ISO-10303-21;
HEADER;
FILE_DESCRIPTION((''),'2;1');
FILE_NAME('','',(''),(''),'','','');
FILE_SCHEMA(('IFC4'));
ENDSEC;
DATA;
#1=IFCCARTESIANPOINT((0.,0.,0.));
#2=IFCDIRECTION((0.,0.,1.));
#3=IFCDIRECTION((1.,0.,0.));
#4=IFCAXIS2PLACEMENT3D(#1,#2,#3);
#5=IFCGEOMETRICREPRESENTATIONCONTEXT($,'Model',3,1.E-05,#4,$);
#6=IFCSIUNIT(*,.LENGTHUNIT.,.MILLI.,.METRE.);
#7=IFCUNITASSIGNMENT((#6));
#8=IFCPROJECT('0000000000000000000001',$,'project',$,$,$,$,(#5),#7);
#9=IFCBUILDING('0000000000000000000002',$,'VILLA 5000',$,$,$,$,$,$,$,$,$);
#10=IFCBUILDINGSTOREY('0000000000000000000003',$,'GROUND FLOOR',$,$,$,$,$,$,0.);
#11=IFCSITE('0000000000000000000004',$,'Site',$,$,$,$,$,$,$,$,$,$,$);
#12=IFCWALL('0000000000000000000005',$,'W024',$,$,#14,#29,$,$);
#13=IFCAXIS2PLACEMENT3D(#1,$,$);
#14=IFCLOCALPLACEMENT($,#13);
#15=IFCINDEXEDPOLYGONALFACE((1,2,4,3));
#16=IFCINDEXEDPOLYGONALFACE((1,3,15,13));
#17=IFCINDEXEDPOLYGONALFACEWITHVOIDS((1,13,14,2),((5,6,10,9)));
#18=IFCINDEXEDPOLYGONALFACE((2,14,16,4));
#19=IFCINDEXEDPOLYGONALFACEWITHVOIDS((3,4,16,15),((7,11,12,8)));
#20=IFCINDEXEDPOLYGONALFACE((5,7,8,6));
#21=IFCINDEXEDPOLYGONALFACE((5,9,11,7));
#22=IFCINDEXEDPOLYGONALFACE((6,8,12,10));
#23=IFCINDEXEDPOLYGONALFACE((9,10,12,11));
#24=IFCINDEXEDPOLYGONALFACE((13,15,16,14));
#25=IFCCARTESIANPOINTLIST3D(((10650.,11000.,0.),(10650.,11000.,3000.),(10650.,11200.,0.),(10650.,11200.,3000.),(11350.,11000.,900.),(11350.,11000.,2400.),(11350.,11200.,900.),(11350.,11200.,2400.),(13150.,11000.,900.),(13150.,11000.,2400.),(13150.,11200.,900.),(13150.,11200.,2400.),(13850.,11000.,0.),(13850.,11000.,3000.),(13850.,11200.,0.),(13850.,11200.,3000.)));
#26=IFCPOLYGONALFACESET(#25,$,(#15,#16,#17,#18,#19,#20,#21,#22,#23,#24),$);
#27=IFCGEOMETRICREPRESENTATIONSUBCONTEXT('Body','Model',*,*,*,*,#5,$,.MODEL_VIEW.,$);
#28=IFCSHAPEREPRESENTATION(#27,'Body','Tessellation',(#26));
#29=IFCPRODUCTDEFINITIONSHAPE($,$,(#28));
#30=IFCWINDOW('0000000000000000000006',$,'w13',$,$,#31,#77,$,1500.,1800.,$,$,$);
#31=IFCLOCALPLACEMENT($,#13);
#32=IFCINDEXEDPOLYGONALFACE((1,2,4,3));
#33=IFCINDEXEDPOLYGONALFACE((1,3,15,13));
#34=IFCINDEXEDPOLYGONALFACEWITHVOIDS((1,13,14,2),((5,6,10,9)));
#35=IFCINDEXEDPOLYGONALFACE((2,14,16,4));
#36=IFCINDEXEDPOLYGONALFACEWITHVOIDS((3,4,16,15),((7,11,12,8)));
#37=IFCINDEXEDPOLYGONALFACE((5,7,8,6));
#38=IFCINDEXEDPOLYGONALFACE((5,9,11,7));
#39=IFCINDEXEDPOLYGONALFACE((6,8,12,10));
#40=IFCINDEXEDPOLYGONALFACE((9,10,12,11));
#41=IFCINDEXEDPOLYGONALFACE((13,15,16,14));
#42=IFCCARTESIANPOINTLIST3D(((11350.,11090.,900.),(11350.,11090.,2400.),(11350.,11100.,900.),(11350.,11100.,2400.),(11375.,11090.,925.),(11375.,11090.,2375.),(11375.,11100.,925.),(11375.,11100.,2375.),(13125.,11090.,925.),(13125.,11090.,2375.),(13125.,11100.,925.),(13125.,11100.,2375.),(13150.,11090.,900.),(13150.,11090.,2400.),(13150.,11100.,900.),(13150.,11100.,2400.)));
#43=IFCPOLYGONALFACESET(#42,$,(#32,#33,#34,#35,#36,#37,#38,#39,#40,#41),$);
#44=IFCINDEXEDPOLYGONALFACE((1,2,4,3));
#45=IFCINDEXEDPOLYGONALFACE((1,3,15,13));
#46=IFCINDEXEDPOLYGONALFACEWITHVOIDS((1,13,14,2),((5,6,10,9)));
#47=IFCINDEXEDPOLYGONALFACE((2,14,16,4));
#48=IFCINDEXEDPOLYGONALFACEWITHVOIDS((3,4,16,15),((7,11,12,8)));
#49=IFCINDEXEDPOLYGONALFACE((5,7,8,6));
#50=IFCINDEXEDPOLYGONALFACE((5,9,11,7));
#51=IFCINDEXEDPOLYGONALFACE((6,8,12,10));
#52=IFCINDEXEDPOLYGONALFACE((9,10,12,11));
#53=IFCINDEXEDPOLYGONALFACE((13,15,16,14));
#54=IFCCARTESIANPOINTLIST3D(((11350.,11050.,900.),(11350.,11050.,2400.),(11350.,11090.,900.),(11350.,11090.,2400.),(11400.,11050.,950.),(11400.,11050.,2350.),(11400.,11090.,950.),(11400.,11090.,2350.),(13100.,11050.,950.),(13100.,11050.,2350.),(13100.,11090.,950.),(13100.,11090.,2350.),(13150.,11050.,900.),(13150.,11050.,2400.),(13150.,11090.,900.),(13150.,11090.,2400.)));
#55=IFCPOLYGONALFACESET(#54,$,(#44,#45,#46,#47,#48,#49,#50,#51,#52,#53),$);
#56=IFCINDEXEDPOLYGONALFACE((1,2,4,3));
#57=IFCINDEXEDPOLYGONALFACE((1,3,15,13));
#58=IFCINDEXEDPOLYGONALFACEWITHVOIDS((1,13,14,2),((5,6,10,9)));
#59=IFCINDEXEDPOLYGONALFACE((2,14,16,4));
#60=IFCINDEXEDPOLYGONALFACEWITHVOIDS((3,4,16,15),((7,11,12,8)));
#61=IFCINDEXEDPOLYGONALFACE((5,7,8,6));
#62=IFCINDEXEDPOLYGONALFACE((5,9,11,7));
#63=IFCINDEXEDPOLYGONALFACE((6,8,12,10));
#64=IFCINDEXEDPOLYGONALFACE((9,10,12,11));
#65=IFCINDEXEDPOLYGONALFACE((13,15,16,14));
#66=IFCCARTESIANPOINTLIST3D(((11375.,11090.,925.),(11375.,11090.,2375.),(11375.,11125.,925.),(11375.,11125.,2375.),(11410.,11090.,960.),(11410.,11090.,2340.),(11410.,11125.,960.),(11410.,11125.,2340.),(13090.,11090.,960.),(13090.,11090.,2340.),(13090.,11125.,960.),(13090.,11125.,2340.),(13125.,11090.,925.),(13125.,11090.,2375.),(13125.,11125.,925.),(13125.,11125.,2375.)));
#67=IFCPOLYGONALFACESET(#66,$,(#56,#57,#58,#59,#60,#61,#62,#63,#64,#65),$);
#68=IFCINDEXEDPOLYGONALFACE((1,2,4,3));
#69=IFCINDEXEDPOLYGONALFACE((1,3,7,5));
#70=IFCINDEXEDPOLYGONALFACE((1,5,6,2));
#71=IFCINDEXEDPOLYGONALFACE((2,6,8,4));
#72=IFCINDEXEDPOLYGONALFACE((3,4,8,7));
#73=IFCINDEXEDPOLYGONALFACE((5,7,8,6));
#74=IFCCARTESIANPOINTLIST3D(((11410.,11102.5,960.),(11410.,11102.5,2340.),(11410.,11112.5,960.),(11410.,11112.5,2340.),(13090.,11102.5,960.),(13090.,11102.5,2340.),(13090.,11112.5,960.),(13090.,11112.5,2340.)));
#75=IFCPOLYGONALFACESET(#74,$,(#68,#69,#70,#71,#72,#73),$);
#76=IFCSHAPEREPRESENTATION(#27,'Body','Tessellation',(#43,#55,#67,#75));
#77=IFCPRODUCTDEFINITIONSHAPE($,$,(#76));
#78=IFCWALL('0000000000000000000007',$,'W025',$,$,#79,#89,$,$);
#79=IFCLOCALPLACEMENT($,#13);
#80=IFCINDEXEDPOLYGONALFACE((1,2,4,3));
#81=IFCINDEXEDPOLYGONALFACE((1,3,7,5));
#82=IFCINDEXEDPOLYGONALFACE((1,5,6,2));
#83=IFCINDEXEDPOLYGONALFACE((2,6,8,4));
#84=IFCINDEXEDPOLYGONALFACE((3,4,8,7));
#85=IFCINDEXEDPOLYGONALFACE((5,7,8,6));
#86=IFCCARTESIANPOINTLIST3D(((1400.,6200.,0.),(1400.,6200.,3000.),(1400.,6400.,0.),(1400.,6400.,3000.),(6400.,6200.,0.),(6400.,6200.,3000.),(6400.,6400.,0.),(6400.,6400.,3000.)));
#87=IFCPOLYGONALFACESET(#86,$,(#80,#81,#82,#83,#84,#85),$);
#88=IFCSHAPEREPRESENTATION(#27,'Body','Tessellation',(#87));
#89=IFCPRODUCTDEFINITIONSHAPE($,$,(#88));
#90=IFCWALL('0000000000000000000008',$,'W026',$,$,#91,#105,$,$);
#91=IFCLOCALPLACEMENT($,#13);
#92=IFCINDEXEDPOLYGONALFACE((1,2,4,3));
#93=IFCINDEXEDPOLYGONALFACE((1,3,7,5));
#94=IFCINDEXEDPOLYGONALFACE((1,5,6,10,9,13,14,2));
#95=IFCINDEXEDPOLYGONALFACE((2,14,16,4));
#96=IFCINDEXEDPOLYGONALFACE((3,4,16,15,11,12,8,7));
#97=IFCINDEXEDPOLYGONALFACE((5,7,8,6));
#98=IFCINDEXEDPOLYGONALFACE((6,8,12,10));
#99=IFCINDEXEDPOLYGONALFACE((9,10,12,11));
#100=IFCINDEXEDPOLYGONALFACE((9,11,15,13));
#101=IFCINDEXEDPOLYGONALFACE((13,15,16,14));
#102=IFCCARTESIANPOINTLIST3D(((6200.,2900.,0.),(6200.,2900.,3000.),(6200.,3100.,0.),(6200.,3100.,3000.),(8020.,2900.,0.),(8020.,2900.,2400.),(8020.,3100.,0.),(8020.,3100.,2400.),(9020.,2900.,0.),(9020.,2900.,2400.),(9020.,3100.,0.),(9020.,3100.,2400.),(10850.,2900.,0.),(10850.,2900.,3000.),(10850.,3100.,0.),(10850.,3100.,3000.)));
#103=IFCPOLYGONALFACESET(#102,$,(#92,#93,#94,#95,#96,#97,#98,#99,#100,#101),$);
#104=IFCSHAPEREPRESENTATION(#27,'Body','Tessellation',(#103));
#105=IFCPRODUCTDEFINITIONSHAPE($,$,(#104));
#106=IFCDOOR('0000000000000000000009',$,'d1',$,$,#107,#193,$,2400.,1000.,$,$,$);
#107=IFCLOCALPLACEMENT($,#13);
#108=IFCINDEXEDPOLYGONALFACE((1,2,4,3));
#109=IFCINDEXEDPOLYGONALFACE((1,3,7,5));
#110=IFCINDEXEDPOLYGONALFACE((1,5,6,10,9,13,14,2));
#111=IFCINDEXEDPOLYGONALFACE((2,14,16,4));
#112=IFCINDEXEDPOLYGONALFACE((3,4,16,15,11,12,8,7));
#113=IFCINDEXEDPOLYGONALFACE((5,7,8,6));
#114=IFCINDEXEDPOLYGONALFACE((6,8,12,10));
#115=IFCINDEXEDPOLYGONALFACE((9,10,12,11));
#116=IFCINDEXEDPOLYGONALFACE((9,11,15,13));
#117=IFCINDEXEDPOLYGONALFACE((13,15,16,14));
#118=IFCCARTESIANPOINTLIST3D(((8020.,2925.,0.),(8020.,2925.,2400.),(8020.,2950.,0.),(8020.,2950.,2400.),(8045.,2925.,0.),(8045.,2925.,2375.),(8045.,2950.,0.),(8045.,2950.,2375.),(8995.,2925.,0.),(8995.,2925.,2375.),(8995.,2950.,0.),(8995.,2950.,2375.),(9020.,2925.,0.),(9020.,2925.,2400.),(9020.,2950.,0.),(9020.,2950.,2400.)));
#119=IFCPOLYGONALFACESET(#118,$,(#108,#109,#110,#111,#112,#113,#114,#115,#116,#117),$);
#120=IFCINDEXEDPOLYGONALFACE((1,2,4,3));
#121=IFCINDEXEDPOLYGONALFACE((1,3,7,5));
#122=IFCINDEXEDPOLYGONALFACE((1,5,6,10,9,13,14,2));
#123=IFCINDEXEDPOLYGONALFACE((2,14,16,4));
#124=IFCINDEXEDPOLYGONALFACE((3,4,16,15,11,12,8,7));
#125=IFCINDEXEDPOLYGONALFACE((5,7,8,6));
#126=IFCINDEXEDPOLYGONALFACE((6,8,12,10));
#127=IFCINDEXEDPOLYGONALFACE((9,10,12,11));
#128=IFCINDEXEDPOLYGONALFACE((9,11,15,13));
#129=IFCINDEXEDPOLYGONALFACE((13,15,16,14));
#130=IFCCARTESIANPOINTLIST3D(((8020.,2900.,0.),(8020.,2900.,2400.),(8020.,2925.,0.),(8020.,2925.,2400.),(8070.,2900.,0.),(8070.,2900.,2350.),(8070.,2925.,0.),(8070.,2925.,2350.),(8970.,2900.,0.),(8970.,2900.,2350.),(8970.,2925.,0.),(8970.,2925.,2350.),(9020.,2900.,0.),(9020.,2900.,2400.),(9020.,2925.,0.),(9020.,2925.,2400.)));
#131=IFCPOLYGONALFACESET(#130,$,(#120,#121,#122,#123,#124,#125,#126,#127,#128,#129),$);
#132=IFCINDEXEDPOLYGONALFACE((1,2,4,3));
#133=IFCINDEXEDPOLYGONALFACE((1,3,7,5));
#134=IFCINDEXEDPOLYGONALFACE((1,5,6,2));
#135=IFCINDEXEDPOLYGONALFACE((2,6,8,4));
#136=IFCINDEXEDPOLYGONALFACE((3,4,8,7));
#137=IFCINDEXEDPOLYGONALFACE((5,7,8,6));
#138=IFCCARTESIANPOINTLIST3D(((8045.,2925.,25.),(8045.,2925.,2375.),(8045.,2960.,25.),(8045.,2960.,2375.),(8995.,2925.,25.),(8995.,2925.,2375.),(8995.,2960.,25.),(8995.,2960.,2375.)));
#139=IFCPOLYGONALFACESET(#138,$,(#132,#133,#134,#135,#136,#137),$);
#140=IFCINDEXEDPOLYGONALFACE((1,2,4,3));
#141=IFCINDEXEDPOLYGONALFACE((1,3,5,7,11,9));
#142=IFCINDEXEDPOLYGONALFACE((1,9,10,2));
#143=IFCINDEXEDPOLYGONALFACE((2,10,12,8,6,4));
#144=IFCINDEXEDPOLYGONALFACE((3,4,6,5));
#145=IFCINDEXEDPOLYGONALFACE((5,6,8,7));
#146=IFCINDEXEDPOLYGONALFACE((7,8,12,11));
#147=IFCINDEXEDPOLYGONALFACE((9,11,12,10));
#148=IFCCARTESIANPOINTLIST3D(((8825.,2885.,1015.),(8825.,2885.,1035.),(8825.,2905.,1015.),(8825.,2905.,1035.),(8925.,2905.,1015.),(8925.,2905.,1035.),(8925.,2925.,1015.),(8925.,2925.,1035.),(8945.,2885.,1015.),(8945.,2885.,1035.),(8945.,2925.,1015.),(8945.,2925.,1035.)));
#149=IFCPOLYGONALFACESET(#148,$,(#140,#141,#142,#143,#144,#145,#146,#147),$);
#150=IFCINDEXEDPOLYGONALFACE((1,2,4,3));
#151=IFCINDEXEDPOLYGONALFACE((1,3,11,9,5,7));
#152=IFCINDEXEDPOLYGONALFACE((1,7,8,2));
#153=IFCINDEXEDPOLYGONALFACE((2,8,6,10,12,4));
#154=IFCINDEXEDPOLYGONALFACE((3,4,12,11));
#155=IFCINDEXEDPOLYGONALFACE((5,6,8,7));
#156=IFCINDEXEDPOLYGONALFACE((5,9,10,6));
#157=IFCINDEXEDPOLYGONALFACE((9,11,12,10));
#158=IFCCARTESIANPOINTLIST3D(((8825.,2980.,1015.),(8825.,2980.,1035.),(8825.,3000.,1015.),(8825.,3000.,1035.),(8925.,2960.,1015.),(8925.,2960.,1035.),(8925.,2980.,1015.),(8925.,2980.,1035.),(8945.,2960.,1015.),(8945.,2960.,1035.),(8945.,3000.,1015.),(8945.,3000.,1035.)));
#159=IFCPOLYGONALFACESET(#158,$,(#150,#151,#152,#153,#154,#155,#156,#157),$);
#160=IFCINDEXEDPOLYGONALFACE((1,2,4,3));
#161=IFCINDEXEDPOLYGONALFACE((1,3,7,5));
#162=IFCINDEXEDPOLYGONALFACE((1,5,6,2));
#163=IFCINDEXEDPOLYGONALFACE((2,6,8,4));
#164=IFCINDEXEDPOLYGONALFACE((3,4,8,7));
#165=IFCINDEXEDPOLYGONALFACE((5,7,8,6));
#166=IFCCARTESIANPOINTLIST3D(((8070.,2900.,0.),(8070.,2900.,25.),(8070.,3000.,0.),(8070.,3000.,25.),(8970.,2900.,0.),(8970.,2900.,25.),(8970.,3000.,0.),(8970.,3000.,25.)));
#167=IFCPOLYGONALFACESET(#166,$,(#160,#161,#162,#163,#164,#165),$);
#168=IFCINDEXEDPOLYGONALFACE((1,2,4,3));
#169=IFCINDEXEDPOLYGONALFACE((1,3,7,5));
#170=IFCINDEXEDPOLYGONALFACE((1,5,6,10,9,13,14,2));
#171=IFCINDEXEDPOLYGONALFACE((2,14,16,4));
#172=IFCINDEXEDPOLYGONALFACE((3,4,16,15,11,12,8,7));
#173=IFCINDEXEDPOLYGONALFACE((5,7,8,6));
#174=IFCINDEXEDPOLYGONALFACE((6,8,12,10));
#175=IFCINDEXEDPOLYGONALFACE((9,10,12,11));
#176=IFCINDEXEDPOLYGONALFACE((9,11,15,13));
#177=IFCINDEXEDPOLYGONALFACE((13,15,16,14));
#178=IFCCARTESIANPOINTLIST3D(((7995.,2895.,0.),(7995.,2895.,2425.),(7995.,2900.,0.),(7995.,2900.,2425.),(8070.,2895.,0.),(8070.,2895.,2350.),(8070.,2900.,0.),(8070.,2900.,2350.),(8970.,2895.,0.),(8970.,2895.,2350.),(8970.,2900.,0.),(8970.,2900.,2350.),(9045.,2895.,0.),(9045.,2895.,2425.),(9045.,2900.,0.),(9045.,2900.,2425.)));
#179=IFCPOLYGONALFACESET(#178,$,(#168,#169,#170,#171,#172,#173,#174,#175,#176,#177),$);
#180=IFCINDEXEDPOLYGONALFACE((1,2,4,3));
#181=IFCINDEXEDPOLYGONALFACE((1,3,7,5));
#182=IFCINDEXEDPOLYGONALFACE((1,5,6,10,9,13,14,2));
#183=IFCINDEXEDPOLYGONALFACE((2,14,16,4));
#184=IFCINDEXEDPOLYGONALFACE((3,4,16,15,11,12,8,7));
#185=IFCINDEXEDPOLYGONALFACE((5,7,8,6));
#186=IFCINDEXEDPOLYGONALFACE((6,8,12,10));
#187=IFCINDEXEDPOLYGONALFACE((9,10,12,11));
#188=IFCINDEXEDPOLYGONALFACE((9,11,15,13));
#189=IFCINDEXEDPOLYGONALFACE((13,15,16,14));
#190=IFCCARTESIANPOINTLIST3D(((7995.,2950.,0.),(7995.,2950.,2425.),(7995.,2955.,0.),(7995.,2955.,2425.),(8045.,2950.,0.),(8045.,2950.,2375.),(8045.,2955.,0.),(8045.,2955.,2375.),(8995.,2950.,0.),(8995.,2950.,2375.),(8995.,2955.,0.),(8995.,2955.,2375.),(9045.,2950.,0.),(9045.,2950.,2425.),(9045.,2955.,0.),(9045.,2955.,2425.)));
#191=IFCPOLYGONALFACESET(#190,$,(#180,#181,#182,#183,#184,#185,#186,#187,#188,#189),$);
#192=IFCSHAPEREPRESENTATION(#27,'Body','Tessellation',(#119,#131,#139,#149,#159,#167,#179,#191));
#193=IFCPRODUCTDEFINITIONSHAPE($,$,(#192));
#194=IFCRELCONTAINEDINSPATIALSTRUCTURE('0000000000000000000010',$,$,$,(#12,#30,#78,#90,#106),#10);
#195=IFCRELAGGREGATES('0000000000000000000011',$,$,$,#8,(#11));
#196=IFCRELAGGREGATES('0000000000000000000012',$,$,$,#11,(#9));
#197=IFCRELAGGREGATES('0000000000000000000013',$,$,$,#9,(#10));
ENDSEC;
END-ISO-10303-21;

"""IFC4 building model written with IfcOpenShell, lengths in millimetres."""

from ifc_helpers import new_model, si_unit, frame, origin_with_axes, place, context, subcontext, project, spatial, line, indexed_curve, outline, extrude, element, fill, save


model = new_model("IFC4")

# Units and contexts
model_context = context("Model", 3, precision=1e-05, world=origin_with_axes())
body_context = subcontext(model_context, "Body", "Model", "MODEL_VIEW")
ifc_project = project(units=[si_unit("LENGTHUNIT", "METRE", prefix="MILLI")], contexts=[model_context])

# Site, building, storey
site = spatial("IfcSite", under=ifc_project, Name="Site")
building = spatial("IfcBuilding", under=site, Name="VILLA 5000")
storey = spatial("IfcBuildingStorey", under=building, Name="GROUND FLOOR", Elevation=0.0)

# Wall, opening, window
wall_1_placement = place(None, frame((10650.0, 11100.0, 0.0), z_axis=(0.0, 0.0, 1.0), x_axis=(1.0, 0.0, 0.0)))
wall_1 = element("IfcWall", 1, at=wall_1_placement, inside=storey, Name="W024", context=body_context, shape_type="SweptSolid", body=[
    extrude(outline(indexed_curve([(0.0, 0.0), (0.0, 200.0), (3200.0, 200.0), (3200.0, 0.0), (0.0, 0.0)], self_intersect=False)), frame((0.0, -100.0, 0.0), z_axis=(0.0, 0.0, 1.0), x_axis=(1.0, 0.0, 0.0)), (0.0, 0.0, 1.0), 3000.0),
])
opening_1_placement = place(wall_1_placement, frame((700.0, 0.0, 900.0), z_axis=(0.0, 0.0, 1.0), x_axis=(1.0, 0.0, 0.0)))
opening_1 = element("IfcOpeningElement", 2, at=opening_1_placement, cuts=wall_1, context=body_context, shape_type="SweptSolid", body=[
    extrude(outline(indexed_curve([(0.0, 0.0), (0.0, 300.0), (1800.0, 300.0), (1800.0, 0.0), (0.0, 0.0)], self_intersect=False)), frame((0.0, -150.0, 0.0), z_axis=(0.0, 0.0, 1.0), x_axis=(1.0, 0.0, 0.0)), (0.0, 0.0, 1.0), 1500.0),
])
window_1_placement = place(None, frame((11350.0, 11000.0, 900.0), z_axis=(0.0, 0.0, 1.0), x_axis=(1.0, 0.0, 0.0)))
window_1 = element("IfcWindow", 3, at=window_1_placement, inside=storey, Name="w13", OverallHeight=1500.0, OverallWidth=1800.0, context=body_context, shape_type="SweptSolid", body=[
    extrude(outline(indexed_curve([(0.0, 0.0), (1800.0, 0.0), (1800.0, 1500.0), (0.0, 1500.0)], segments=[line(1, 2, 3, 4, 1)]), holes=[indexed_curve([(25.0, 25.0), (1775.0, 25.0), (1775.0, 1475.0), (25.0, 1475.0)], segments=[line(1, 2, 3, 4, 1)])]), frame((0.0, 90.0, 0.0), z_axis=(0.0, -1.0, 0.0), x_axis=(1.0, 0.0, 0.0)), (0.0, 0.0, -1.0), 10.0),
    extrude(outline(indexed_curve([(0.0, 0.0), (1800.0, 0.0), (1800.0, 1500.0), (0.0, 1500.0)], segments=[line(1, 2, 3, 4, 1)]), holes=[indexed_curve([(50.0, 50.0), (1750.0, 50.0), (1750.0, 1450.0), (50.0, 1450.0)], segments=[line(1, 2, 3, 4, 1)])]), frame((0.0, 50.0, 0.0), z_axis=(0.0, -1.0, 0.0), x_axis=(1.0, 0.0, 0.0)), (0.0, 0.0, -1.0), 40.0),
    extrude(outline(indexed_curve([(0.0, 0.0), (1750.0, 0.0), (1750.0, 1450.0), (0.0, 1450.0)], segments=[line(1, 2, 3, 4, 1)]), holes=[indexed_curve([(35.0, 35.0), (1715.0, 35.0), (1715.0, 1415.0), (35.0, 1415.0)], segments=[line(1, 2, 3, 4, 1)])]), frame((25.0, 90.0, 25.0), z_axis=(0.0, -1.0, 0.0), x_axis=(1.0, 0.0, 0.0)), (0.0, 0.0, -1.0), 35.0),
    extrude(outline(indexed_curve([(35.0, 35.0), (1715.0, 35.0), (1715.0, 1415.0), (35.0, 1415.0)], segments=[line(1, 2, 3, 4, 1)])), frame((25.0, 102.5, 25.0), z_axis=(0.0, -1.0, 0.0), x_axis=(1.0, 0.0, 0.0)), (0.0, 0.0, -1.0), 10.0),
])
fill(opening_1, window_1)

# Wall
wall_2_placement = place(None, frame((1400.0, 6300.0, 0.0), z_axis=(0.0, 0.0, 1.0), x_axis=(1.0, 0.0, 0.0)))
element("IfcWall", 4, at=wall_2_placement, inside=storey, Name="W025", context=body_context, shape_type="SweptSolid", body=[
    extrude(outline(indexed_curve([(0.0, 0.0), (0.0, 200.0), (5000.0, 200.0), (5000.0, 0.0), (0.0, 0.0)], self_intersect=False)), frame((0.0, -100.0, 0.0), z_axis=(0.0, 0.0, 1.0), x_axis=(1.0, 0.0, 0.0)), (0.0, 0.0, 1.0), 3000.0),
])

# Wall, opening, door
wall_3_placement = place(None, frame((6200.0, 3000.0, 0.0), z_axis=(0.0, 0.0, 1.0), x_axis=(1.0, 0.0, 0.0)))
wall_3 = element("IfcWall", 5, at=wall_3_placement, inside=storey, Name="W026", context=body_context, shape_type="SweptSolid", body=[
    extrude(outline(indexed_curve([(0.0, 0.0), (0.0, 200.0), (4650.0, 200.0), (4650.0, 0.0), (0.0, 0.0)], self_intersect=False)), frame((0.0, -100.0, 0.0), z_axis=(0.0, 0.0, 1.0), x_axis=(1.0, 0.0, 0.0)), (0.0, 0.0, 1.0), 3000.0),
])
opening_2_placement = place(wall_3_placement, frame((1820.0, 0.0, 0.0), z_axis=(0.0, 0.0, 1.0), x_axis=(1.0, 0.0, 0.0)))
opening_2 = element("IfcOpeningElement", 6, at=opening_2_placement, cuts=wall_3, context=body_context, shape_type="SweptSolid", body=[
    extrude(outline(indexed_curve([(0.0, 0.0), (0.0, 300.0), (1000.0, 300.0), (1000.0, 0.0), (0.0, 0.0)], self_intersect=False)), frame((0.0, -150.0, 0.0), z_axis=(0.0, 0.0, 1.0), x_axis=(1.0, 0.0, 0.0)), (0.0, 0.0, 1.0), 2400.0),
])
door_1_placement = place(None, frame((8020.0, 2900.0, 0.0), z_axis=(0.0, 0.0, 1.0), x_axis=(1.0, 0.0, 0.0)))
door_1 = element("IfcDoor", 7, at=door_1_placement, inside=storey, Name="d1", OverallHeight=2400.0, OverallWidth=1000.0, context=body_context, shape_type="SweptSolid", body=[
    extrude(outline(indexed_curve([(0.0, 0.0), (0.0, 2400.0), (1000.0, 2400.0), (1000.0, 0.0), (975.0, 0.0), (975.0, 2375.0), (25.0, 2375.0), (25.0, 0.0)], segments=[line(1, 2, 3, 4, 5, 6, 7, 8, 1)])), frame((0.0, 25.0, 0.0), z_axis=(0.0, -1.0, 0.0), x_axis=(1.0, 0.0, 0.0)), (0.0, 0.0, -1.0), 25.0),
    extrude(outline(indexed_curve([(0.0, 0.0), (0.0, 2400.0), (1000.0, 2400.0), (1000.0, 0.0), (950.0, 0.0), (950.0, 2350.0), (50.0, 2350.0), (50.0, 0.0)], segments=[line(1, 2, 3, 4, 5, 6, 7, 8, 1)])), frame((0.0, 0.0, 0.0), z_axis=(0.0, -1.0, 0.0), x_axis=(1.0, 0.0, 0.0)), (0.0, 0.0, -1.0), 25.0),
    extrude(outline(indexed_curve([(0.0, 0.0), (950.0, 0.0), (950.0, 35.0), (0.0, 35.0)], segments=[line(1, 2, 3, 4, 1)])), frame((25.0, 25.0, 25.0), z_axis=(0.0, 0.0, 1.0), x_axis=(1.0, 0.0, 0.0)), (0.0, 0.0, 1.0), 2350.0),
    extrude(outline(indexed_curve([(0.0, 0.0), (0.0, -40.0), (-120.0, -40.0), (-120.0, -20.0), (-20.0, -20.0), (-20.0, 0.0)], segments=[line(1, 2, 3, 4, 5, 6, 1)])), frame((925.0, 25.0, 1015.0), z_axis=(0.0, 0.0, 1.0), x_axis=(1.0, 0.0, 0.0)), (0.0, 0.0, 1.0), 20.0),
    extrude(outline(indexed_curve([(0.0, 0.0), (0.0, 40.0), (-120.0, 40.0), (-120.0, 20.0), (-20.0, 20.0), (-20.0, 0.0)], segments=[line(1, 2, 3, 4, 5, 6, 1)])), frame((925.0, 60.0, 1015.0), z_axis=(0.0, 0.0, 1.0), x_axis=(1.0, 0.0, 0.0)), (0.0, 0.0, 1.0), 20.0),
    extrude(outline(indexed_curve([(0.0, 0.0), (900.0, 0.0), (900.0, 100.0), (0.0, 100.0)], segments=[line(1, 2, 3, 4, 1)])), frame((50.0, 0.0, 0.0), z_axis=(0.0, 0.0, 1.0), x_axis=(1.0, 0.0, 0.0)), (0.0, 0.0, 1.0), 25.0),
    extrude(outline(indexed_curve([(0.0, 0.0), (0.0, 2425.0), (1050.0, 2425.0), (1050.0, 0.0), (975.0, 0.0), (975.0, 2350.0), (75.0, 2350.0), (75.0, 0.0)], segments=[line(1, 2, 3, 4, 5, 6, 7, 8, 1)])), frame((-25.0, -5.0, 0.0), z_axis=(0.0, -1.0, 0.0), x_axis=(1.0, 0.0, 0.0)), (0.0, 0.0, -1.0), 5.0),
    extrude(outline(indexed_curve([(0.0, 0.0), (0.0, 2425.0), (1050.0, 2425.0), (1050.0, 0.0), (1000.0, 0.0), (1000.0, 2375.0), (50.0, 2375.0), (50.0, 0.0)], segments=[line(1, 2, 3, 4, 5, 6, 7, 8, 1)])), frame((-25.0, 50.0, 0.0), z_axis=(0.0, -1.0, 0.0), x_axis=(1.0, 0.0, 0.0)), (0.0, 0.0, -1.0), 5.0),
])
fill(opening_2, door_1)

save(model, "model.ifc")
